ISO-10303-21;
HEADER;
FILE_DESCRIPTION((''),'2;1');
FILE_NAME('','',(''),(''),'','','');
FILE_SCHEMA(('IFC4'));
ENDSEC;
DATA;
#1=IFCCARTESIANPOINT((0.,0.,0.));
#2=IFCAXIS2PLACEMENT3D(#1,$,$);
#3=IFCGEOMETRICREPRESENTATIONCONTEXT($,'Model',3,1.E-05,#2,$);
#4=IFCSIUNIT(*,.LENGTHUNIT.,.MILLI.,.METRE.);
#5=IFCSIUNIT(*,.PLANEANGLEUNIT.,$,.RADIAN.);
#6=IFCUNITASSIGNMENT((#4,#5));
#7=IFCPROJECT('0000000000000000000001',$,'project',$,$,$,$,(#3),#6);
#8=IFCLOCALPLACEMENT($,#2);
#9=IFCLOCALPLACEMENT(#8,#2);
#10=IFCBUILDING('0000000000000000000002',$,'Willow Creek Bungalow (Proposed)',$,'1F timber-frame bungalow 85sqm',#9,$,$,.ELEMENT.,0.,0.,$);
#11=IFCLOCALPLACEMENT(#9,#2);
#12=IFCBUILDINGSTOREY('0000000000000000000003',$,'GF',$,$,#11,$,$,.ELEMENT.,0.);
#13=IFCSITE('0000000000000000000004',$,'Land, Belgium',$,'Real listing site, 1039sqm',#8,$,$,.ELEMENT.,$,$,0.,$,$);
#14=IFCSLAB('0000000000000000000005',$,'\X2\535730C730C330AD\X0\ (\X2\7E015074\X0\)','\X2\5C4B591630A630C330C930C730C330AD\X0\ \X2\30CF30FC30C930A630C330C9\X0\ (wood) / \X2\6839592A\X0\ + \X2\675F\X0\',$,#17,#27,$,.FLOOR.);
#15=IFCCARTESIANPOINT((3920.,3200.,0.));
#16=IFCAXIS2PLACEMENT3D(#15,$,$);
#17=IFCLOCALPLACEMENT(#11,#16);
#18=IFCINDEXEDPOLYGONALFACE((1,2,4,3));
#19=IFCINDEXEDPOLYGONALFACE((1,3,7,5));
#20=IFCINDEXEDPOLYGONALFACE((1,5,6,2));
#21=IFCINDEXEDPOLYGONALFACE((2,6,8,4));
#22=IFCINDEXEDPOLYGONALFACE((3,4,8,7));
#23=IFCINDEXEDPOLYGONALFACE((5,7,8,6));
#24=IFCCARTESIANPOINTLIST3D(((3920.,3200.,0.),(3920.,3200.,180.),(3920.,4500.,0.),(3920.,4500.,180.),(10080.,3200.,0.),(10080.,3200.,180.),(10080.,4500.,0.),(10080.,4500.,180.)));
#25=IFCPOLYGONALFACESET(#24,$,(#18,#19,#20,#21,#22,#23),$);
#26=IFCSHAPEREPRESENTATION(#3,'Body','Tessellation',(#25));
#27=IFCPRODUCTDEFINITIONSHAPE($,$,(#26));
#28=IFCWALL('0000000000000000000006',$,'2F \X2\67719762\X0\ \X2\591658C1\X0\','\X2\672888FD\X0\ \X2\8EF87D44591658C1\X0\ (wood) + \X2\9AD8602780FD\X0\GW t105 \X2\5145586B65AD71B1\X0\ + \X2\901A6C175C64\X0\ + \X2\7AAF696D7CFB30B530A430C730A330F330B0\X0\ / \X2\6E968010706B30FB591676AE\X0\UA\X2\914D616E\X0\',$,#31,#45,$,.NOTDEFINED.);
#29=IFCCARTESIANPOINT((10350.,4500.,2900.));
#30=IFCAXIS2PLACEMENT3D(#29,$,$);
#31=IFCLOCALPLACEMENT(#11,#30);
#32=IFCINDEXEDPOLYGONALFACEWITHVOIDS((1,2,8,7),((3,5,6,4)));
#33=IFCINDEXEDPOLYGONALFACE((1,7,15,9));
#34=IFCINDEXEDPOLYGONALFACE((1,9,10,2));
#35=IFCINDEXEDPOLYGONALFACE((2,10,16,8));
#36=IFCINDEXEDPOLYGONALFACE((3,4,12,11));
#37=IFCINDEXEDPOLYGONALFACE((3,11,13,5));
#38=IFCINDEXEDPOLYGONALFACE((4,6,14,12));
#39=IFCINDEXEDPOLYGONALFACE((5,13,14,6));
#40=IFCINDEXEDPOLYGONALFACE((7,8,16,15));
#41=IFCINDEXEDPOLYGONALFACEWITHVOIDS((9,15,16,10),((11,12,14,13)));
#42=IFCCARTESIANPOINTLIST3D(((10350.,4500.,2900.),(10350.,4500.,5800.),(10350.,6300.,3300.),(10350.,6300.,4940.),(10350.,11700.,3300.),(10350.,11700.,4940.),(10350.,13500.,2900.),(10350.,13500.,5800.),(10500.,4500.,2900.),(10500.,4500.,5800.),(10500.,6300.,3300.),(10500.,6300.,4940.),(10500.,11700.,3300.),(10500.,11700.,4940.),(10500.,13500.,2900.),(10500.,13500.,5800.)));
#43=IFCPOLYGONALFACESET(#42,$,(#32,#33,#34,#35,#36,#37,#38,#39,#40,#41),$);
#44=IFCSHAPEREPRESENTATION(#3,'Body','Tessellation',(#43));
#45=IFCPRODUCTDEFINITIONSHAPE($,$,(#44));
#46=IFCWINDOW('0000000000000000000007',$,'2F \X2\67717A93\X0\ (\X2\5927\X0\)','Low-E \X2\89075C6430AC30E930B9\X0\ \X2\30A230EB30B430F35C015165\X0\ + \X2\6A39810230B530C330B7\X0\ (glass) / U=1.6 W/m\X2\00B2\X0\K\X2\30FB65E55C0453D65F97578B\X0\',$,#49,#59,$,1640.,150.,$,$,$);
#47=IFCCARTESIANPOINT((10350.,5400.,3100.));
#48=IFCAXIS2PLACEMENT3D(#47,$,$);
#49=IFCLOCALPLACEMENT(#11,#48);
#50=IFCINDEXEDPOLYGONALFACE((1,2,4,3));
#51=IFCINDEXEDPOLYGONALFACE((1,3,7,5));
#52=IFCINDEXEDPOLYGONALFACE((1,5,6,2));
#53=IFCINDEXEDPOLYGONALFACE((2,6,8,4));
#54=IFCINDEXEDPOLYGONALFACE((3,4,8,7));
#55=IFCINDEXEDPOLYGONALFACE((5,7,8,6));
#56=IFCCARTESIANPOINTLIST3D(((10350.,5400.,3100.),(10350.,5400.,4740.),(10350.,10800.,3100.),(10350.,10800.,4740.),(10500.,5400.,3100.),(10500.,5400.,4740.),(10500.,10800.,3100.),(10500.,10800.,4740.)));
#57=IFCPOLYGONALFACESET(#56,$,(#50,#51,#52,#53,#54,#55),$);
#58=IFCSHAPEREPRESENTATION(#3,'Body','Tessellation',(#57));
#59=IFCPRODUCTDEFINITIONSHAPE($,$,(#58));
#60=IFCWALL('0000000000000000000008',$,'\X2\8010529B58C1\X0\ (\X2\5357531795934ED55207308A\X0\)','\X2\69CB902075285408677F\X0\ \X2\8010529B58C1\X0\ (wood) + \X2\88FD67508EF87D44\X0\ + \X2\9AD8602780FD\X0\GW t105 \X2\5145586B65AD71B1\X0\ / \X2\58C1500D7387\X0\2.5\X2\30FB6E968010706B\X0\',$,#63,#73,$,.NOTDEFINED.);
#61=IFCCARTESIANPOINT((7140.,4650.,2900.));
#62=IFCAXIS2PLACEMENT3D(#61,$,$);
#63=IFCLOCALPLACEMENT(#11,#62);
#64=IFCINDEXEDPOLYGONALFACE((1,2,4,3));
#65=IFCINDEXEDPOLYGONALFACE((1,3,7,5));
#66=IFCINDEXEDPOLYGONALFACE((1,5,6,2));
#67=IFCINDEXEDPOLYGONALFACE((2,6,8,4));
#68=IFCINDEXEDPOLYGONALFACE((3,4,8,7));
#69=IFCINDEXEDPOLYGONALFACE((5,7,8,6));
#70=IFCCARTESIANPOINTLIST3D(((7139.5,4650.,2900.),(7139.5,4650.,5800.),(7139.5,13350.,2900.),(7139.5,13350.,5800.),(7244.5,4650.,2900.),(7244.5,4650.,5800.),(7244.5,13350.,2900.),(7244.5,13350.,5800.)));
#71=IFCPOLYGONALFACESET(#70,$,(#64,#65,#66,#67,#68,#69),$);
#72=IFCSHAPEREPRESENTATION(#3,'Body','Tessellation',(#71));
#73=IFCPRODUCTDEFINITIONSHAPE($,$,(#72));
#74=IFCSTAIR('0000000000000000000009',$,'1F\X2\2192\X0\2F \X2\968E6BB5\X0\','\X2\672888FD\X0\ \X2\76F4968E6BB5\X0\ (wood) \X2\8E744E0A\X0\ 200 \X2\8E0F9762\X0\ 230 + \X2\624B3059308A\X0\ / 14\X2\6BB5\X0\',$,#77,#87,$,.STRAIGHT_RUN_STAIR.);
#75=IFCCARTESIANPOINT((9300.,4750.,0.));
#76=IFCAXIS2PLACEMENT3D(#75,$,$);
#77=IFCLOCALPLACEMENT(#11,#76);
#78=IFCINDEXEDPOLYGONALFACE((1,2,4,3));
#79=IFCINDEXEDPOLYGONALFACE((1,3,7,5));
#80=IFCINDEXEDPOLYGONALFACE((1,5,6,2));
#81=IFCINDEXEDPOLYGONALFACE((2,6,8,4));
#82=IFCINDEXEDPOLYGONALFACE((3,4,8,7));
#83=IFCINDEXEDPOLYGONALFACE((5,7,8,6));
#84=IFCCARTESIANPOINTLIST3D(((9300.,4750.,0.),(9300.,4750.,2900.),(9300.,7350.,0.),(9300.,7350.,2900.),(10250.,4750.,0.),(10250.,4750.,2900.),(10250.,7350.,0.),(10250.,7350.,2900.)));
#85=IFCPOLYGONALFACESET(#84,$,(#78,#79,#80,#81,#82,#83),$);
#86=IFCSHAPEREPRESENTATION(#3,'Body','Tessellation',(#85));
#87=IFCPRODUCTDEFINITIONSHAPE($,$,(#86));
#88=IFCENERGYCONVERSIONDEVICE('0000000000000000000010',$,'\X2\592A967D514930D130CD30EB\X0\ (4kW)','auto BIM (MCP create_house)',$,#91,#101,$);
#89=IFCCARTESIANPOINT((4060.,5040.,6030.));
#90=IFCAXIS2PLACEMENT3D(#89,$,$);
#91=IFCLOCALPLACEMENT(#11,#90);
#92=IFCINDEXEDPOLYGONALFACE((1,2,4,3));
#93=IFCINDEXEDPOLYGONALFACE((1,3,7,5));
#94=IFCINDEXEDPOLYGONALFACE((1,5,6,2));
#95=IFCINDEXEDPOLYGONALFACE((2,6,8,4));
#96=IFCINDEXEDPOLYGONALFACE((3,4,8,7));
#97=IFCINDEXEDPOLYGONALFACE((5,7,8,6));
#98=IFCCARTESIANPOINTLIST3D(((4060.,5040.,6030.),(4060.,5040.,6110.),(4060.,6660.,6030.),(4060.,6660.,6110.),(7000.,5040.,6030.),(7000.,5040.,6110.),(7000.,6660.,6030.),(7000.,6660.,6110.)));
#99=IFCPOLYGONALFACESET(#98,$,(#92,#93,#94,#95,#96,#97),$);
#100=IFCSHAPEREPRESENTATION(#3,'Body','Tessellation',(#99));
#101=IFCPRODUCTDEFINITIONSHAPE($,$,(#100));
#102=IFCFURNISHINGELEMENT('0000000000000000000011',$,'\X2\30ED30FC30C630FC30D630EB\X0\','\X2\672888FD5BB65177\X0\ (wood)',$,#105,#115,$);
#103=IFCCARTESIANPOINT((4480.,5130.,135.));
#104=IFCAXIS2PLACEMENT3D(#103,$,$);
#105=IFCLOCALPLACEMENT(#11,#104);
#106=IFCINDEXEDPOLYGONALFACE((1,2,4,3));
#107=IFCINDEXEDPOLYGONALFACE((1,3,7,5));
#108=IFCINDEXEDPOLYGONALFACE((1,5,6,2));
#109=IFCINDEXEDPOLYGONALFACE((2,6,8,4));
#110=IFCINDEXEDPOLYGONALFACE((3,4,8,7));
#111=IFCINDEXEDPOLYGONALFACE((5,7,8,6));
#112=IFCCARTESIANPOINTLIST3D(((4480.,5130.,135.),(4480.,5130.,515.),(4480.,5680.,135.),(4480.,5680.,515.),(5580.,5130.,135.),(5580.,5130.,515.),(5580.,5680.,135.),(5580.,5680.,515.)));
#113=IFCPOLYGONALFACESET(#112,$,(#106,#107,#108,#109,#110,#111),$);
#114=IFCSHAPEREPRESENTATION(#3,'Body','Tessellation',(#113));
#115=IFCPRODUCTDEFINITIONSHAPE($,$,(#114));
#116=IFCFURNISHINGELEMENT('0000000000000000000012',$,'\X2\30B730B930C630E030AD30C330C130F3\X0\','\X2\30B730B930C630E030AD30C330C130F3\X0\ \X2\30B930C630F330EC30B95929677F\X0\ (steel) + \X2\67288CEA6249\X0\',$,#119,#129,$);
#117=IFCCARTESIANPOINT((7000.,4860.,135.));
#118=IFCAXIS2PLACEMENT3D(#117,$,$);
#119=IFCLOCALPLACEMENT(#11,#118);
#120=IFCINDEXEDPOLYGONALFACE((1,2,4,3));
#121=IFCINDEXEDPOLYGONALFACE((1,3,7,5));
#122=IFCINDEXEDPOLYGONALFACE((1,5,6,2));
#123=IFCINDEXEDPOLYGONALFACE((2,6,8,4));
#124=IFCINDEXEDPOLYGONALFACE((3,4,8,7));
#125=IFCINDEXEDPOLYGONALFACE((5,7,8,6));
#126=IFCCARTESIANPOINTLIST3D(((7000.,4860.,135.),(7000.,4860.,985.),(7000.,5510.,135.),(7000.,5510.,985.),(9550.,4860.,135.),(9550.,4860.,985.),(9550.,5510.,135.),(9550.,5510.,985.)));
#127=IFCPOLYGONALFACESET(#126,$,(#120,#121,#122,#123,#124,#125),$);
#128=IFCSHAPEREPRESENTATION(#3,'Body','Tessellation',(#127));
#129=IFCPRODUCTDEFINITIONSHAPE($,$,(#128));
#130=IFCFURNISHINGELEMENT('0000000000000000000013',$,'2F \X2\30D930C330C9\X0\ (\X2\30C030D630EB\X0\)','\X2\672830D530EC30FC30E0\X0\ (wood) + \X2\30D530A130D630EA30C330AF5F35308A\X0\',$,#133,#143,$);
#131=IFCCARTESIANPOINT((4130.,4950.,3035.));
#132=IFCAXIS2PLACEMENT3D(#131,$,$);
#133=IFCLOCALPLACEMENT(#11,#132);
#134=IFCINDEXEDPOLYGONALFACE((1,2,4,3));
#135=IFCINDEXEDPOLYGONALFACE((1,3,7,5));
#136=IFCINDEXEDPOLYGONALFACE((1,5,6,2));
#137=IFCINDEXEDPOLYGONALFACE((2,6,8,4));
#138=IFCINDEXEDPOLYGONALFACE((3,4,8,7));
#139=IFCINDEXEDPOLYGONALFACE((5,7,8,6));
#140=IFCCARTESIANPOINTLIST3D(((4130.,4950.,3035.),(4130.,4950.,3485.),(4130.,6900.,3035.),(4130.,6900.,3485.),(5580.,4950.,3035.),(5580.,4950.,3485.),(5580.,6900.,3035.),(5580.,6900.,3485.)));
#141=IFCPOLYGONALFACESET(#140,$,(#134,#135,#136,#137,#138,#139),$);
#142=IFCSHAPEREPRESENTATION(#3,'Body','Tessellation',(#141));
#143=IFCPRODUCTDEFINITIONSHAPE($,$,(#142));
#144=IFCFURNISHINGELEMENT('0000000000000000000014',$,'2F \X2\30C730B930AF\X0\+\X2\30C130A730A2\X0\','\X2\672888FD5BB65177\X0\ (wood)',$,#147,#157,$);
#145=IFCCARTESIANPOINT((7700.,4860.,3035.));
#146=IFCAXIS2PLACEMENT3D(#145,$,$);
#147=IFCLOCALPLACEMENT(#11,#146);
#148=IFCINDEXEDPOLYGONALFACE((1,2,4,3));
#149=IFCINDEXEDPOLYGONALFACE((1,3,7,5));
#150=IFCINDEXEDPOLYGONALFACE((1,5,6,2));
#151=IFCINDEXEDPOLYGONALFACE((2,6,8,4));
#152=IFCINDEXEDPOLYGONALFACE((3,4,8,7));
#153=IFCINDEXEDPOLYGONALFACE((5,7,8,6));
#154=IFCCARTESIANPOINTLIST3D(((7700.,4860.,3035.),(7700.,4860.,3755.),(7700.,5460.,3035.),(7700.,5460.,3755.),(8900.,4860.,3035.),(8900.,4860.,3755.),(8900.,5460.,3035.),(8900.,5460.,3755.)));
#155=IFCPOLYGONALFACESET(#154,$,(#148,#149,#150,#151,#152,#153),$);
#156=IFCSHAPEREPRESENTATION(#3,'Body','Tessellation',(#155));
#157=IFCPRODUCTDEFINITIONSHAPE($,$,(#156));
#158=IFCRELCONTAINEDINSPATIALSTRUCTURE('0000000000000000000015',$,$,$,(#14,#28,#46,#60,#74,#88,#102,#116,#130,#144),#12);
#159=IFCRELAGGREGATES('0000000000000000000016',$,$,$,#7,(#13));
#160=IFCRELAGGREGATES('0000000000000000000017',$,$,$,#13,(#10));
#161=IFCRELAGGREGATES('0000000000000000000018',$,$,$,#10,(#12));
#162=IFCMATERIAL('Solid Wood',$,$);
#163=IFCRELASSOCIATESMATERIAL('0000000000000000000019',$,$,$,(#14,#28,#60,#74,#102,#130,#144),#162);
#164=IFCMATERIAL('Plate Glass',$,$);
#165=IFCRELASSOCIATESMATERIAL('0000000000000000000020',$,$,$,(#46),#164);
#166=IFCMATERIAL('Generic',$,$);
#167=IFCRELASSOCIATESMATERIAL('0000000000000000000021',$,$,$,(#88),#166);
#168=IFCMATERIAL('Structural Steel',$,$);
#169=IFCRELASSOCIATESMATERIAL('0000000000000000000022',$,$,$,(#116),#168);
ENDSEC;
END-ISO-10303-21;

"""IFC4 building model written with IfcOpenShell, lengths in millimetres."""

from ifc_helpers import new_model, si_unit, frame, frame_2d, origin, place, context, project, spatial, rectangle, extrude, material, element, fill, save


model = new_model("IFC4")

# Units and contexts
model_context = context("Model", 3, precision=1e-05, world=origin())
ifc_project = project(units=[si_unit("LENGTHUNIT", "METRE", prefix="MILLI"), si_unit("PLANEANGLEUNIT", "RADIAN")], contexts=[model_context])

# Site, building, storey
site_placement = place(None, origin())
site = spatial("IfcSite", under=ifc_project, at=site_placement, Name="Land, Belgium", ObjectType="Real listing site, 1039sqm", CompositionType="ELEMENT", RefElevation=0.0)
building_placement = place(site_placement, origin())
building = spatial("IfcBuilding", under=site, at=building_placement, Name="Willow Creek Bungalow (Proposed)", ObjectType="1F timber-frame bungalow 85sqm", CompositionType="ELEMENT", ElevationOfRefHeight=0.0, ElevationOfTerrain=0.0)
storey_placement = place(building_placement, origin())
storey = spatial("IfcBuildingStorey", under=building, at=storey_placement, Name="GF", CompositionType="ELEMENT", Elevation=0.0)

# Slab
ifc_material_1 = material(Name="Solid Wood")
slab_placement = place(storey_placement, frame((3920.0, 3200.0, 0.0)))
element("IfcSlab", 1, at=slab_placement, inside=storey, material=ifc_material_1, Name="南デッキ (縁側)", Description="屋外ウッドデッキ ハードウッド (wood) / 根太 + 束", PredefinedType="FLOOR", context=model_context, shape_type="SweptSolid", body=[
    extrude(rectangle(XDim=6160.0, YDim=1300.0, at=frame_2d((3080.0, 650.0))), frame((3920.0, 3200.0, 0.0)), (0.0, 0.0, 1.0), 180.0),
])

# Shared definitions
ifc_material_2 = material(Name="Plate Glass")

# Wall, opening, window
wall_1_placement = place(storey_placement, frame((10350.0, 4500.0, 2900.0)))
wall_1 = element("IfcWall", 2, at=wall_1_placement, inside=storey, material=ifc_material_1, Name="2F 東面 外壁", Description="木製 軸組外壁 (wood) + 高性能GW t105 充填断熱 + 通気層 + 窯業系サイディング / 準耐火・外皮UA配慮", PredefinedType="NOTDEFINED", context=model_context, shape_type="SweptSolid", body=[
    extrude(rectangle(XDim=150.0, YDim=9000.0, at=frame_2d((75.0, 4500.0))), frame((10350.0, 4500.0, 2900.0)), (0.0, 0.0, 1.0), 2900.0),
])
opening_1_placement = place(storey_placement, frame((10350.0, 5400.0, 3100.0)))
opening_1 = element("IfcOpeningElement", 3, at=opening_1_placement, cuts=wall_1, PredefinedType="NOTDEFINED", context=model_context, shape_type="SweptSolid", body=[
    extrude(rectangle(XDim=150.0, YDim=5400.0, at=frame_2d((75.0, 2700.0))), frame((10350.0, 5400.0, 3100.0)), (0.0, 0.0, 1.0), 1640.0),
])
window_1_placement = place(storey_placement, frame((10350.0, 5400.0, 3100.0)))
window_1 = element("IfcWindow", 4, at=window_1_placement, inside=storey, material=ifc_material_2, Name="2F 東窓 (大)", Description="Low-E 複層ガラス アルゴン封入 + 樹脂サッシ (glass) / U=1.6 W/m²K・日射取得型", OverallHeight=1640.0, OverallWidth=150.0, context=model_context, shape_type="SweptSolid", body=[
    extrude(rectangle(XDim=150.0, YDim=5400.0, at=frame_2d((75.0, 2700.0))), frame((10350.0, 5400.0, 3100.0)), (0.0, 0.0, 1.0), 1640.0),
])
fill(opening_1, window_1)

# Wall
wall_2_placement = place(storey_placement, frame((7140.0, 4650.0, 2900.0)))
element("IfcWall", 5, at=wall_2_placement, inside=storey, material=ifc_material_1, Name="耐力壁 (南北間仕切り)", Description="構造用合板 耐力壁 (wood) + 製材軸組 + 高性能GW t105 充填断熱 / 壁倍率2.5・準耐火", PredefinedType="NOTDEFINED", context=model_context, shape_type="SweptSolid", body=[
    extrude(rectangle(XDim=105.0, YDim=8700.0, at=frame_2d((52.0, 4350.0))), frame((7140.0, 4650.0, 2900.0)), (0.0, 0.0, 1.0), 2900.0),
])

# Stair
stair_placement = place(storey_placement, frame((9300.0, 4750.0, 0.0)))
element("IfcStair", 6, at=stair_placement, inside=storey, material=ifc_material_1, Name="1F→2F 階段", Description="木製 直階段 (wood) 蹴上 200 踏面 230 + 手すり / 14段", PredefinedType="STRAIGHT_RUN_STAIR", context=model_context, shape_type="SweptSolid", body=[
    extrude(rectangle(XDim=950.0, YDim=2600.0, at=frame_2d((475.0, 1300.0))), frame((9300.0, 4750.0, 0.0)), (0.0, 0.0, 1.0), 2900.0),
])

# Energy conversion device
ifc_material_3 = material(Name="Generic")
energy_conversion_device_placement = place(storey_placement, frame((4060.0, 5040.0, 6030.0)))
element("IfcEnergyConversionDevice", 7, at=energy_conversion_device_placement, inside=storey, material=ifc_material_3, Name="太陽光パネル (4kW)", Description="auto BIM (MCP create_house)", context=model_context, shape_type="SweptSolid", body=[
    extrude(rectangle(XDim=2940.0, YDim=1620.0, at=frame_2d((1470.0, 810.0))), frame((4060.0, 5040.0, 6030.0)), (0.0, 0.0, 1.0), 80.0),
])

# Furnishing elements
furnishing_1_placement = place(storey_placement, frame((4480.0, 5130.0, 135.0)))
element("IfcFurnishingElement", 8, at=furnishing_1_placement, inside=storey, material=ifc_material_1, Name="ローテーブル", Description="木製家具 (wood)", context=model_context, shape_type="SweptSolid", body=[
    extrude(rectangle(XDim=1100.0, YDim=550.0, at=frame_2d((550.0, 275.0))), frame((4480.0, 5130.0, 135.0)), (0.0, 0.0, 1.0), 380.0),
])
ifc_material_4 = material(Name="Structural Steel")
furnishing_2_placement = place(storey_placement, frame((7000.0, 4860.0, 135.0)))
element("IfcFurnishingElement", 9, at=furnishing_2_placement, inside=storey, material=ifc_material_4, Name="システムキッチン", Description="システムキッチン ステンレス天板 (steel) + 木質扉", context=model_context, shape_type="SweptSolid", body=[
    extrude(rectangle(XDim=2550.0, YDim=650.0, at=frame_2d((1275.0, 325.0))), frame((7000.0, 4860.0, 135.0)), (0.0, 0.0, 1.0), 850.0),
])
furnishing_3_placement = place(storey_placement, frame((4130.0, 4950.0, 3035.0)))
element("IfcFurnishingElement", 10, at=furnishing_3_placement, inside=storey, material=ifc_material_1, Name="2F ベッド (ダブル)", Description="木フレーム (wood) + ファブリック張り", context=model_context, shape_type="SweptSolid", body=[
    extrude(rectangle(XDim=1450.0, YDim=1950.0, at=frame_2d((725.0, 975.0))), frame((4130.0, 4950.0, 3035.0)), (0.0, 0.0, 1.0), 450.0),
])
furnishing_4_placement = place(storey_placement, frame((7700.0, 4860.0, 3035.0)))
element("IfcFurnishingElement", 11, at=furnishing_4_placement, inside=storey, material=ifc_material_1, Name="2F デスク+チェア", Description="木製家具 (wood)", context=model_context, shape_type="SweptSolid", body=[
    extrude(rectangle(XDim=1200.0, YDim=600.0, at=frame_2d((600.0, 300.0))), frame((7700.0, 4860.0, 3035.0)), (0.0, 0.0, 1.0), 720.0),
])

save(model, "model.ifc")
